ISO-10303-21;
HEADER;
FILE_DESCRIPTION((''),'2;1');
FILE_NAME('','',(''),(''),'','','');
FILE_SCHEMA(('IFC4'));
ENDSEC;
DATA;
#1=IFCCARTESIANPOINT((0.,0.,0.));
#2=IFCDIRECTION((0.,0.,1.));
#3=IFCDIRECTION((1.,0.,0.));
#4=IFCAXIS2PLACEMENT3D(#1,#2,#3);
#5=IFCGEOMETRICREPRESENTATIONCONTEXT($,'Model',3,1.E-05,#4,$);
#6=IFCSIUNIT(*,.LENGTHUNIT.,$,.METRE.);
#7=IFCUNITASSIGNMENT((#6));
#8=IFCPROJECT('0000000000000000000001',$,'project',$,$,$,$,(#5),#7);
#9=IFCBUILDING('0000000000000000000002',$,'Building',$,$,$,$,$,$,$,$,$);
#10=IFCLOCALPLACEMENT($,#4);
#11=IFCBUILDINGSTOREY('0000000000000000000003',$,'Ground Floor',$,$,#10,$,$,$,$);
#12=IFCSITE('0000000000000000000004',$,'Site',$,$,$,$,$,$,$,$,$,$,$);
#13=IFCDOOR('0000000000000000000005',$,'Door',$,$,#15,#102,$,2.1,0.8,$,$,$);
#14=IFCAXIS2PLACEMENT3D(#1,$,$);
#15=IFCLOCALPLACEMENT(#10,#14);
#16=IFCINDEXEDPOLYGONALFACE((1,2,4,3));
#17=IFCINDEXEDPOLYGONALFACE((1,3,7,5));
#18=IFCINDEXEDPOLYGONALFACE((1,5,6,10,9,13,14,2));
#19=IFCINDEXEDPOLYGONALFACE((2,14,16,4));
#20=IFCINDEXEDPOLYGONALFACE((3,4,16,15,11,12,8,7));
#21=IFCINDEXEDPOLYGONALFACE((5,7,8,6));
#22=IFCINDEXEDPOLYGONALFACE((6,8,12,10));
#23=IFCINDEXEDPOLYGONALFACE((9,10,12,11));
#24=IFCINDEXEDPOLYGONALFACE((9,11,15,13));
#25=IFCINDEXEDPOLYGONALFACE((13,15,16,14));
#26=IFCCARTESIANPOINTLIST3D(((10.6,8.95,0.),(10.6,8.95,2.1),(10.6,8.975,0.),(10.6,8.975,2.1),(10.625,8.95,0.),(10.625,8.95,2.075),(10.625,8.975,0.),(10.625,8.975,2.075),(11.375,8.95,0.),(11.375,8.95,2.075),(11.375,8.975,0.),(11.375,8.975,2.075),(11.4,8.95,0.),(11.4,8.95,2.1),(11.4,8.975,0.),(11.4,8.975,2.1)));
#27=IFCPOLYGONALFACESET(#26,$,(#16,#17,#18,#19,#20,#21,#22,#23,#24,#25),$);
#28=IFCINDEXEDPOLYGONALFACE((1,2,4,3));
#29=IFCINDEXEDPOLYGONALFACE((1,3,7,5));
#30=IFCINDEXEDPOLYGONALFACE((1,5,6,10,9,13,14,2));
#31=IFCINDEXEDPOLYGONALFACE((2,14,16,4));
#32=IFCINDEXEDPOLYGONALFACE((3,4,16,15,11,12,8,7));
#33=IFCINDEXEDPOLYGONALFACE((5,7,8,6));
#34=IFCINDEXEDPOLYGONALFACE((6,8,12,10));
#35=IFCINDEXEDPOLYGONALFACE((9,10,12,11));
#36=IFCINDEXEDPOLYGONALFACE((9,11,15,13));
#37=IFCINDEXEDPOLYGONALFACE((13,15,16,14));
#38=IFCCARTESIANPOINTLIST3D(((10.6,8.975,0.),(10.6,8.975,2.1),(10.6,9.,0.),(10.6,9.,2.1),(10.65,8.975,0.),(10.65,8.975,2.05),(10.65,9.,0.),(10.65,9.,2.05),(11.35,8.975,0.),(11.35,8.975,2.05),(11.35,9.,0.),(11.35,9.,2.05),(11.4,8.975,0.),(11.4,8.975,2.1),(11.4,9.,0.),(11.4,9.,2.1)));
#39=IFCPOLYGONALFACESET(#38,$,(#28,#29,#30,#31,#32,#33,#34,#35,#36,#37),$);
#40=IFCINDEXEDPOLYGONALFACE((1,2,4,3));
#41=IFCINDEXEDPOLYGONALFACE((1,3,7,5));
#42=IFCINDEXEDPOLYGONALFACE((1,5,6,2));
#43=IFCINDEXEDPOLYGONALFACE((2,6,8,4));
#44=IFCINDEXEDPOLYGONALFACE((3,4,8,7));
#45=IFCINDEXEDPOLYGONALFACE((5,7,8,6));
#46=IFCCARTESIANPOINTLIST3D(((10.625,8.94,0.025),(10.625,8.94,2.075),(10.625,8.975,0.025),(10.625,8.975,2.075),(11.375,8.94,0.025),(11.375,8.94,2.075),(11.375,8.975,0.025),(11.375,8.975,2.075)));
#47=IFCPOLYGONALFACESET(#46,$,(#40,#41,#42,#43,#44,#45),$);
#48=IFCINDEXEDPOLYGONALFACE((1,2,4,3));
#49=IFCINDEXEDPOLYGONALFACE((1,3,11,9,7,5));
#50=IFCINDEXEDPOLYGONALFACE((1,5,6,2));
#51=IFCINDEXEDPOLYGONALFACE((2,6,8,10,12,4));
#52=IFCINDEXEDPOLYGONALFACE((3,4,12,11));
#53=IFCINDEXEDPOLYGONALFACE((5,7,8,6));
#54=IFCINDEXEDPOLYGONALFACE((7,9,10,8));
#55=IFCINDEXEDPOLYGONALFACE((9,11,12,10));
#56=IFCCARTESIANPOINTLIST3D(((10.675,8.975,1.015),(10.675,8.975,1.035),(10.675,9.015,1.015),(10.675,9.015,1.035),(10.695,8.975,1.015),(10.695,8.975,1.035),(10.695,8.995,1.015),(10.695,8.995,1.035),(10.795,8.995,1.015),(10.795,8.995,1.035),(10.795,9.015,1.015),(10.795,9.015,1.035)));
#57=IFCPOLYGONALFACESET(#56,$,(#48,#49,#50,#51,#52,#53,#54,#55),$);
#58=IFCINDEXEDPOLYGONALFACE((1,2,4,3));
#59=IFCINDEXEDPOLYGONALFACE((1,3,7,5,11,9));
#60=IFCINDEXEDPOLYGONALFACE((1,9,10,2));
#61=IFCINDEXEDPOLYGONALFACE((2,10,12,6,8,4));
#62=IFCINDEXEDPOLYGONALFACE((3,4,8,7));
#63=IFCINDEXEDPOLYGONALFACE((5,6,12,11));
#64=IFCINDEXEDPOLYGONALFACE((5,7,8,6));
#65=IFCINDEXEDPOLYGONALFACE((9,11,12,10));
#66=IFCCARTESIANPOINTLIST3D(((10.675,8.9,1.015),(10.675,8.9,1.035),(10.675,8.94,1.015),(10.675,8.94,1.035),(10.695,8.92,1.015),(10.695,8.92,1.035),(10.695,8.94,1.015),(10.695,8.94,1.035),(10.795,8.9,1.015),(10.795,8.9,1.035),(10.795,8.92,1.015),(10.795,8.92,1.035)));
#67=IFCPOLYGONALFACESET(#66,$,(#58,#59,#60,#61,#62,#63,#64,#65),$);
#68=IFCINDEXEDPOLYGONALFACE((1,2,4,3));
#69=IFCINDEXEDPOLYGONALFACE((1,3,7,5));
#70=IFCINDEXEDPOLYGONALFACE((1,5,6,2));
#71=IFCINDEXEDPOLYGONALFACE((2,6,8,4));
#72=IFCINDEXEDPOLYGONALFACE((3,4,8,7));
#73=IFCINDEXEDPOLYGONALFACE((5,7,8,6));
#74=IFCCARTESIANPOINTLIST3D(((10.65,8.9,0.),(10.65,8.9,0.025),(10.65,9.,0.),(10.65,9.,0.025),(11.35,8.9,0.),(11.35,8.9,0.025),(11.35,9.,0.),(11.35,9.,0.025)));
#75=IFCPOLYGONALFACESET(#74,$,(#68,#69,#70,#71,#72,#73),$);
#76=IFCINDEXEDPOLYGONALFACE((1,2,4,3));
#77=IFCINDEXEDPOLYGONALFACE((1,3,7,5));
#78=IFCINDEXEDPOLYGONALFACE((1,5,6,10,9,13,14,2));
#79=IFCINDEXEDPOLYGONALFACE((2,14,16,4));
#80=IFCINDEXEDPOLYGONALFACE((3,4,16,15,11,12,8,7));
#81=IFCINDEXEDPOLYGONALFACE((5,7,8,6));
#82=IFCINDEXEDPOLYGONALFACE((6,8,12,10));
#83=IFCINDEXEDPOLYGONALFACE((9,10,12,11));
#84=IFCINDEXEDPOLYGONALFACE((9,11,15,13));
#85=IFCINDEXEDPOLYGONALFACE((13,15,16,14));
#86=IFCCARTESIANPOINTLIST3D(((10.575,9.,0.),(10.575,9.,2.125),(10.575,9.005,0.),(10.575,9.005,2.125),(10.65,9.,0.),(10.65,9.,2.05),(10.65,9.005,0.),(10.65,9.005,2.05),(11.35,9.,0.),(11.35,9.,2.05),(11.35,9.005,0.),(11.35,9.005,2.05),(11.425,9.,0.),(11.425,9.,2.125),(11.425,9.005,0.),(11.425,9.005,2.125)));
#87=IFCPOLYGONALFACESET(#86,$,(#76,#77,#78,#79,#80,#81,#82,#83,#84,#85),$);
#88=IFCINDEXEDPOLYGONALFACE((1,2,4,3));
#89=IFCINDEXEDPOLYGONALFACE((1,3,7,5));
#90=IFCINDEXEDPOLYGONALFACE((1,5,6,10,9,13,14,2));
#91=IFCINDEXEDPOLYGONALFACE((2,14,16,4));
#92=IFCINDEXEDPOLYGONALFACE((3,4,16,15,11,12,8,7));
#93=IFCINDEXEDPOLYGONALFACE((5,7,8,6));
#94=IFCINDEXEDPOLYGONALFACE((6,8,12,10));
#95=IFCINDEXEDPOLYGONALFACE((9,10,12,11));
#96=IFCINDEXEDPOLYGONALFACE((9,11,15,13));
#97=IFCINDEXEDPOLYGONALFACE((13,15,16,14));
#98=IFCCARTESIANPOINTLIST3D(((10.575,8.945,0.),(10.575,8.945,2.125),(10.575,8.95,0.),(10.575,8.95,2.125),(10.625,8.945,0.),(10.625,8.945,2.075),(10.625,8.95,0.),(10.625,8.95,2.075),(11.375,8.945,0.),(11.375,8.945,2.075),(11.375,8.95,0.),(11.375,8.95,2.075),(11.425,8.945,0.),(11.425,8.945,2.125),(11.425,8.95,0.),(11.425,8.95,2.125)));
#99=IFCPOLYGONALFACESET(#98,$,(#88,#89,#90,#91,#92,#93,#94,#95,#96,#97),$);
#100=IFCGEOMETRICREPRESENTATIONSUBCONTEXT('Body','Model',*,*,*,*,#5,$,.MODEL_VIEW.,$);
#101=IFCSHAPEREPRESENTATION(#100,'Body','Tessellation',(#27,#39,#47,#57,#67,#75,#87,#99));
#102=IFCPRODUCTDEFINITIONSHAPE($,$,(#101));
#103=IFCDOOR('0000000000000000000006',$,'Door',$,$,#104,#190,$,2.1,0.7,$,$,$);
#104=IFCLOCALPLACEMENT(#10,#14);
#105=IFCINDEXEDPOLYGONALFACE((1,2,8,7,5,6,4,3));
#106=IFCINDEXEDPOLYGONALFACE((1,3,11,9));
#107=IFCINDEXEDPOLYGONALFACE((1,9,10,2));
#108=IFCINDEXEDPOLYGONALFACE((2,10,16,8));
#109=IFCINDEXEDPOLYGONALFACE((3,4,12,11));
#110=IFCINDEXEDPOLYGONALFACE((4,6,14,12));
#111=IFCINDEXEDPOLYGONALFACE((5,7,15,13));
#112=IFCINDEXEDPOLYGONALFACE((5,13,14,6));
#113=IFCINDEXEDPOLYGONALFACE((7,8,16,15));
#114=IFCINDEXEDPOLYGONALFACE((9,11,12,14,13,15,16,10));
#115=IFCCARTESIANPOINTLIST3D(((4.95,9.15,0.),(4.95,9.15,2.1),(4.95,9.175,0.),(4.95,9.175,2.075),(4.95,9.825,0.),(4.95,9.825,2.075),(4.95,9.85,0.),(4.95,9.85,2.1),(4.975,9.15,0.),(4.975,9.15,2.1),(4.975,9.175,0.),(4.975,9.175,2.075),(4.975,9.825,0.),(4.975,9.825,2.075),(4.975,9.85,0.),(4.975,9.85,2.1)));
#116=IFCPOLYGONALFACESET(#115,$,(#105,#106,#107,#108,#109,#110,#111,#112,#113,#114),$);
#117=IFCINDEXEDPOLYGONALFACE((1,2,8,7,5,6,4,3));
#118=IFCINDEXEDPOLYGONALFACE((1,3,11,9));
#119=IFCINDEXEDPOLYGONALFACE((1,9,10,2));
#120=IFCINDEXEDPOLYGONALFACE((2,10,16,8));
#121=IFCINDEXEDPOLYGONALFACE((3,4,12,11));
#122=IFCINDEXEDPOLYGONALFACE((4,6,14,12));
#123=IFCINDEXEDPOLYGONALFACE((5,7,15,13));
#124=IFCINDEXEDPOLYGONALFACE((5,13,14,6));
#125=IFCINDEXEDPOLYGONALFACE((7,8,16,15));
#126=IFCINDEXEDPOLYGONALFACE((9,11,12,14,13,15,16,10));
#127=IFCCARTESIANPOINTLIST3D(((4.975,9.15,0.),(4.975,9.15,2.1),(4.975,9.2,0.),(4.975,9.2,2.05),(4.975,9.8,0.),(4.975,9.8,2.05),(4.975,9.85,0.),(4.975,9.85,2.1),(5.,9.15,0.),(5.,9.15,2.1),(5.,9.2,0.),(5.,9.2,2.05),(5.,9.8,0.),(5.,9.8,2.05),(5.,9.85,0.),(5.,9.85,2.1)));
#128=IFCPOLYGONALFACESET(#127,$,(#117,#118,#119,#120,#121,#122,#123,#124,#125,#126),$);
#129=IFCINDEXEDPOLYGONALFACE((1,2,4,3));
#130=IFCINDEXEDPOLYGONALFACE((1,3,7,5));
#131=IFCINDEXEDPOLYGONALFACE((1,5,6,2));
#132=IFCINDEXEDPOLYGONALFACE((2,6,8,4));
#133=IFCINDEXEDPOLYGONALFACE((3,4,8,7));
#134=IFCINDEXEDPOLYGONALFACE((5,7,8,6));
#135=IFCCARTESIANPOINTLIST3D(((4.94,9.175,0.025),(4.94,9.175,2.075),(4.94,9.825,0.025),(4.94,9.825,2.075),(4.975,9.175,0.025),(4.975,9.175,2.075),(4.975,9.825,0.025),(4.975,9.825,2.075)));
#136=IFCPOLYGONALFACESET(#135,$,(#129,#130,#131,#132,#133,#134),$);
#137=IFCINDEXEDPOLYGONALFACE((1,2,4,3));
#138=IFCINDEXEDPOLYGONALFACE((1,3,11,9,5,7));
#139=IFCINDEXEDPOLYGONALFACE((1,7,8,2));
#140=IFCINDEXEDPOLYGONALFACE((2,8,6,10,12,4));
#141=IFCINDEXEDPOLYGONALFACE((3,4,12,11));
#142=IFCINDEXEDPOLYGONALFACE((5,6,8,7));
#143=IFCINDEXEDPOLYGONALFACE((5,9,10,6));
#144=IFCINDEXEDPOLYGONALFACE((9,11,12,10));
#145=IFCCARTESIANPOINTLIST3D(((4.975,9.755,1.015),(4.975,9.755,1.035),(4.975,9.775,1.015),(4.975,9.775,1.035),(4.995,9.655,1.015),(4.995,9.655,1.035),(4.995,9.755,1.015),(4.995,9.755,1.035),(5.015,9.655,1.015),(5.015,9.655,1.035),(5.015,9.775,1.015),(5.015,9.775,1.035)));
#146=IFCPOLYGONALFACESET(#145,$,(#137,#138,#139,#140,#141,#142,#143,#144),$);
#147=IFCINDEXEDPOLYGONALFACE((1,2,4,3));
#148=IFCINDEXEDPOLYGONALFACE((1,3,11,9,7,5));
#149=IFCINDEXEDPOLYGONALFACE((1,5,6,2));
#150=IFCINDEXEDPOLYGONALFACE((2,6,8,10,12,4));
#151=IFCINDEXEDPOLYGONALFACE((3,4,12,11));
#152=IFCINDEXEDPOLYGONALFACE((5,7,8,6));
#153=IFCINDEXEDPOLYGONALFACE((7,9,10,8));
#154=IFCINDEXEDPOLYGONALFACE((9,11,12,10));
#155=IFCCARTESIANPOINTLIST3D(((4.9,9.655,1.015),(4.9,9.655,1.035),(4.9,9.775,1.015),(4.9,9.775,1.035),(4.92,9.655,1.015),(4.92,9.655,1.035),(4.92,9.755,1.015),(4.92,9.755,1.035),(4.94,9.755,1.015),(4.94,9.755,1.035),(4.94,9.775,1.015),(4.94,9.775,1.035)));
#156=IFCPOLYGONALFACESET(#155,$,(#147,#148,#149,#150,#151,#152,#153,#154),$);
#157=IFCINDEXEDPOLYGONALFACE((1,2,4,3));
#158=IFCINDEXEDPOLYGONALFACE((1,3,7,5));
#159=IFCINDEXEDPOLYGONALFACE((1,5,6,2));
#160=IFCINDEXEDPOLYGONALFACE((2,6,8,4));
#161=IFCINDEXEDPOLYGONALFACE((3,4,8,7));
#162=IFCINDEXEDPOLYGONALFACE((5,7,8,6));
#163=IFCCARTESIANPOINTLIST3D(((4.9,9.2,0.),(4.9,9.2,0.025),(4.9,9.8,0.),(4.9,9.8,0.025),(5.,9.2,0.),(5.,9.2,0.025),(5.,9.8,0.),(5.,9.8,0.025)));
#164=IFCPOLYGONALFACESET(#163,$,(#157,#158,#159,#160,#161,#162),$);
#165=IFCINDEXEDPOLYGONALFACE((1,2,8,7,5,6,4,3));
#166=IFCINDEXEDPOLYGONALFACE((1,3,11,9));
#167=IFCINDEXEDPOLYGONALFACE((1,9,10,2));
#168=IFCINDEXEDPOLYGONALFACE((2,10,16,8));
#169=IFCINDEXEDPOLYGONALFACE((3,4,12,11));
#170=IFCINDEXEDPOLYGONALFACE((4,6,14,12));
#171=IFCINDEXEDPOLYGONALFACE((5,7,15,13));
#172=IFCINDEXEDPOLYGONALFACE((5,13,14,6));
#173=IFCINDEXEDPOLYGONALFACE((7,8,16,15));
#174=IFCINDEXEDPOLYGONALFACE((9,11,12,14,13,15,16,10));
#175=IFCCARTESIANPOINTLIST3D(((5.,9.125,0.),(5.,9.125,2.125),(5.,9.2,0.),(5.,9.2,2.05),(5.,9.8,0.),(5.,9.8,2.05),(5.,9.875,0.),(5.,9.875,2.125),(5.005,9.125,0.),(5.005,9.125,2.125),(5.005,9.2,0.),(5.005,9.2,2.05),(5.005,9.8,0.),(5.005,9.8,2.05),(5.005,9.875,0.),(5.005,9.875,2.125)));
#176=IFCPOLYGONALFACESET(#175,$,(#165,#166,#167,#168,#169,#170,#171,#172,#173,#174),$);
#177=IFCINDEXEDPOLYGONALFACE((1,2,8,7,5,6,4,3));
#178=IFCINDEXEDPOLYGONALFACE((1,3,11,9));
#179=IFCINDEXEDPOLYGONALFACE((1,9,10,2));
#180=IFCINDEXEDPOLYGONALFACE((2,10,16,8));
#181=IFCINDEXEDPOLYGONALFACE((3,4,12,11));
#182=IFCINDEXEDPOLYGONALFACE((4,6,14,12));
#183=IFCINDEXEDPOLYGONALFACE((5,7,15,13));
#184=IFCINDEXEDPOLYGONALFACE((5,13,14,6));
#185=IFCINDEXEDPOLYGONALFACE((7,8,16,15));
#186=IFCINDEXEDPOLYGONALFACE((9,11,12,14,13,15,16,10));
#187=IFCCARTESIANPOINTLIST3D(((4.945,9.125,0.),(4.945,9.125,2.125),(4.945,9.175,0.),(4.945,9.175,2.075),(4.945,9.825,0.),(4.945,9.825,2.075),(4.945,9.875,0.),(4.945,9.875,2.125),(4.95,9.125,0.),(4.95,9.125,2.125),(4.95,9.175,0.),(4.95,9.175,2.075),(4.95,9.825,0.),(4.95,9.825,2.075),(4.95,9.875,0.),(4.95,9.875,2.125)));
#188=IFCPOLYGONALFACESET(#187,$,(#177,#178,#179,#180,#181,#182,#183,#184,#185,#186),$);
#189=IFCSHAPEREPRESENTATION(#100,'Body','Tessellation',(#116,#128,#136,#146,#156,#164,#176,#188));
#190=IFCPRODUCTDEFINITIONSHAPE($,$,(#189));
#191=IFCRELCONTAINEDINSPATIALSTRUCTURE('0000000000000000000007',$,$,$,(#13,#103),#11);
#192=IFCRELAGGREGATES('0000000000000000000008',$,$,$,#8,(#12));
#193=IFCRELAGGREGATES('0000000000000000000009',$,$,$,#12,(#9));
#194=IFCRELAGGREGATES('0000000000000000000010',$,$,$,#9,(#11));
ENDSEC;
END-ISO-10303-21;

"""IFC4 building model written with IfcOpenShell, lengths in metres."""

from ifc_helpers import new_model, si_unit, frame, origin_with_axes, place, context, subcontext, project, spatial, line, indexed_curve, outline, extrude, element, save


model = new_model("IFC4")

# Units and contexts
model_context = context("Model", 3, precision=1e-05, world=origin_with_axes())
body_context = subcontext(model_context, "Body", "Model", "MODEL_VIEW")
ifc_project = project(units=[si_unit("LENGTHUNIT", "METRE")], contexts=[model_context])

# Site, building, storey
site = spatial("IfcSite", under=ifc_project, Name="Site")
building = spatial("IfcBuilding", under=site, Name="Building")
storey_placement = place(None, origin_with_axes())
storey = spatial("IfcBuildingStorey", under=building, at=storey_placement, Name="Ground Floor")

# Doors
door_1_placement = place(storey_placement, frame((11.4, 9.0, 0.0), z_axis=(0.0, 0.0, 1.0), x_axis=(-1.0, 0.0, 0.0)))
element("IfcDoor", 1, at=door_1_placement, inside=storey, Name="Door", OverallHeight=2.1, OverallWidth=0.8, context=body_context, shape_type="SweptSolid", body=[
    extrude(outline(indexed_curve([(0.0, 0.0), (0.0, 2.1), (0.8, 2.1), (0.8, 0.0), (0.775, 0.0), (0.775, 2.075), (0.025, 2.075), (0.025, 0.0)], segments=[line(1, 2, 3, 4, 5, 6, 7, 8, 1)])), frame((0.0, 0.025, 0.0), z_axis=(0.0, -1.0, 0.0), x_axis=(1.0, 0.0, 0.0)), (0.0, 0.0, -1.0), 0.025),
    extrude(outline(indexed_curve([(0.0, 0.0), (0.0, 2.1), (0.8, 2.1), (0.8, 0.0), (0.75, 0.0), (0.75, 2.05), (0.05, 2.05), (0.05, 0.0)], segments=[line(1, 2, 3, 4, 5, 6, 7, 8, 1)])), frame((0.0, 0.0, 0.0), z_axis=(0.0, -1.0, 0.0), x_axis=(1.0, 0.0, 0.0)), (0.0, 0.0, -1.0), 0.025),
    extrude(outline(indexed_curve([(0.0, 0.0), (0.75, 0.0), (0.75, 0.035), (0.0, 0.035)], segments=[line(1, 2, 3, 4, 1)])), frame((0.025, 0.025, 0.025), z_axis=(0.0, 0.0, 1.0), x_axis=(1.0, 0.0, 0.0)), (0.0, 0.0, 1.0), 2.05),
    extrude(outline(indexed_curve([(0.0, 0.0), (0.0, -0.04), (-0.12, -0.04), (-0.12, -0.02), (-0.02, -0.02), (-0.02, 0.0)], segments=[line(1, 2, 3, 4, 5, 6, 1)])), frame((0.725, 0.025, 1.015), z_axis=(0.0, 0.0, 1.0), x_axis=(1.0, 0.0, 0.0)), (0.0, 0.0, 1.0), 0.02),
    extrude(outline(indexed_curve([(0.0, 0.0), (0.0, 0.04), (-0.12, 0.04), (-0.12, 0.02), (-0.02, 0.02), (-0.02, 0.0)], segments=[line(1, 2, 3, 4, 5, 6, 1)])), frame((0.725, 0.06, 1.015), z_axis=(0.0, 0.0, 1.0), x_axis=(1.0, 0.0, 0.0)), (0.0, 0.0, 1.0), 0.02),
    extrude(outline(indexed_curve([(0.0, 0.0), (0.7, 0.0), (0.7, 0.1), (0.0, 0.1)], segments=[line(1, 2, 3, 4, 1)])), frame((0.05, 0.0, 0.0), z_axis=(0.0, 0.0, 1.0), x_axis=(1.0, 0.0, 0.0)), (0.0, 0.0, 1.0), 0.025),
    extrude(outline(indexed_curve([(0.0, 0.0), (0.0, 2.125), (0.85, 2.125), (0.85, 0.0), (0.775, 0.0), (0.775, 2.05), (0.075, 2.05), (0.075, 0.0)], segments=[line(1, 2, 3, 4, 5, 6, 7, 8, 1)])), frame((-0.025, -0.005, 0.0), z_axis=(0.0, -1.0, 0.0), x_axis=(1.0, 0.0, 0.0)), (0.0, 0.0, -1.0), 0.005),
    extrude(outline(indexed_curve([(0.0, 0.0), (0.0, 2.125), (0.85, 2.125), (0.85, 0.0), (0.8, 0.0), (0.8, 2.075), (0.05, 2.075), (0.05, 0.0)], segments=[line(1, 2, 3, 4, 5, 6, 7, 8, 1)])), frame((-0.025, 0.05, 0.0), z_axis=(0.0, -1.0, 0.0), x_axis=(1.0, 0.0, 0.0)), (0.0, 0.0, -1.0), 0.005),
])
door_2_placement = place(storey_placement, frame((5.0, 9.15, 0.0), z_axis=(0.0, 0.0, 1.0), x_axis=(0.0, 1.0, 0.0)))
element("IfcDoor", 2, at=door_2_placement, inside=storey, Name="Door", OverallHeight=2.1, OverallWidth=0.7, context=body_context, shape_type="SweptSolid", body=[
    extrude(outline(indexed_curve([(0.0, 0.0), (0.0, 2.1), (0.7, 2.1), (0.7, 0.0), (0.675, 0.0), (0.675, 2.075), (0.025, 2.075), (0.025, 0.0)], segments=[line(1, 2, 3, 4, 5, 6, 7, 8, 1)])), frame((0.0, 0.025, 0.0), z_axis=(0.0, -1.0, 0.0), x_axis=(1.0, 0.0, 0.0)), (0.0, 0.0, -1.0), 0.025),
    extrude(outline(indexed_curve([(0.0, 0.0), (0.0, 2.1), (0.7, 2.1), (0.7, 0.0), (0.65, 0.0), (0.65, 2.05), (0.05, 2.05), (0.05, 0.0)], segments=[line(1, 2, 3, 4, 5, 6, 7, 8, 1)])), frame((0.0, 0.0, 0.0), z_axis=(0.0, -1.0, 0.0), x_axis=(1.0, 0.0, 0.0)), (0.0, 0.0, -1.0), 0.025),
    extrude(outline(indexed_curve([(0.0, 0.0), (0.65, 0.0), (0.65, 0.035), (0.0, 0.035)], segments=[line(1, 2, 3, 4, 1)])), frame((0.025, 0.025, 0.025), z_axis=(0.0, 0.0, 1.0), x_axis=(1.0, 0.0, 0.0)), (0.0, 0.0, 1.0), 2.05),
    extrude(outline(indexed_curve([(0.0, 0.0), (0.0, -0.04), (-0.12, -0.04), (-0.12, -0.02), (-0.02, -0.02), (-0.02, 0.0)], segments=[line(1, 2, 3, 4, 5, 6, 1)])), frame((0.625, 0.025, 1.015), z_axis=(0.0, 0.0, 1.0), x_axis=(1.0, 0.0, 0.0)), (0.0, 0.0, 1.0), 0.02),
    extrude(outline(indexed_curve([(0.0, 0.0), (0.0, 0.04), (-0.12, 0.04), (-0.12, 0.02), (-0.02, 0.02), (-0.02, 0.0)], segments=[line(1, 2, 3, 4, 5, 6, 1)])), frame((0.625, 0.06, 1.015), z_axis=(0.0, 0.0, 1.0), x_axis=(1.0, 0.0, 0.0)), (0.0, 0.0, 1.0), 0.02),
    extrude(outline(indexed_curve([(0.0, 0.0), (0.6, 0.0), (0.6, 0.1), (0.0, 0.1)], segments=[line(1, 2, 3, 4, 1)])), frame((0.05, 0.0, 0.0), z_axis=(0.0, 0.0, 1.0), x_axis=(1.0, 0.0, 0.0)), (0.0, 0.0, 1.0), 0.025),
    extrude(outline(indexed_curve([(0.0, 0.0), (0.0, 2.125), (0.75, 2.125), (0.75, 0.0), (0.675, 0.0), (0.675, 2.05), (0.075, 2.05), (0.075, 0.0)], segments=[line(1, 2, 3, 4, 5, 6, 7, 8, 1)])), frame((-0.025, -0.005, 0.0), z_axis=(0.0, -1.0, 0.0), x_axis=(1.0, 0.0, 0.0)), (0.0, 0.0, -1.0), 0.005),
    extrude(outline(indexed_curve([(0.0, 0.0), (0.0, 2.125), (0.75, 2.125), (0.75, 0.0), (0.7, 0.0), (0.7, 2.075), (0.05, 2.075), (0.05, 0.0)], segments=[line(1, 2, 3, 4, 5, 6, 7, 8, 1)])), frame((-0.025, 0.05, 0.0), z_axis=(0.0, -1.0, 0.0), x_axis=(1.0, 0.0, 0.0)), (0.0, 0.0, -1.0), 0.005),
])

save(model, "model.ifc")
